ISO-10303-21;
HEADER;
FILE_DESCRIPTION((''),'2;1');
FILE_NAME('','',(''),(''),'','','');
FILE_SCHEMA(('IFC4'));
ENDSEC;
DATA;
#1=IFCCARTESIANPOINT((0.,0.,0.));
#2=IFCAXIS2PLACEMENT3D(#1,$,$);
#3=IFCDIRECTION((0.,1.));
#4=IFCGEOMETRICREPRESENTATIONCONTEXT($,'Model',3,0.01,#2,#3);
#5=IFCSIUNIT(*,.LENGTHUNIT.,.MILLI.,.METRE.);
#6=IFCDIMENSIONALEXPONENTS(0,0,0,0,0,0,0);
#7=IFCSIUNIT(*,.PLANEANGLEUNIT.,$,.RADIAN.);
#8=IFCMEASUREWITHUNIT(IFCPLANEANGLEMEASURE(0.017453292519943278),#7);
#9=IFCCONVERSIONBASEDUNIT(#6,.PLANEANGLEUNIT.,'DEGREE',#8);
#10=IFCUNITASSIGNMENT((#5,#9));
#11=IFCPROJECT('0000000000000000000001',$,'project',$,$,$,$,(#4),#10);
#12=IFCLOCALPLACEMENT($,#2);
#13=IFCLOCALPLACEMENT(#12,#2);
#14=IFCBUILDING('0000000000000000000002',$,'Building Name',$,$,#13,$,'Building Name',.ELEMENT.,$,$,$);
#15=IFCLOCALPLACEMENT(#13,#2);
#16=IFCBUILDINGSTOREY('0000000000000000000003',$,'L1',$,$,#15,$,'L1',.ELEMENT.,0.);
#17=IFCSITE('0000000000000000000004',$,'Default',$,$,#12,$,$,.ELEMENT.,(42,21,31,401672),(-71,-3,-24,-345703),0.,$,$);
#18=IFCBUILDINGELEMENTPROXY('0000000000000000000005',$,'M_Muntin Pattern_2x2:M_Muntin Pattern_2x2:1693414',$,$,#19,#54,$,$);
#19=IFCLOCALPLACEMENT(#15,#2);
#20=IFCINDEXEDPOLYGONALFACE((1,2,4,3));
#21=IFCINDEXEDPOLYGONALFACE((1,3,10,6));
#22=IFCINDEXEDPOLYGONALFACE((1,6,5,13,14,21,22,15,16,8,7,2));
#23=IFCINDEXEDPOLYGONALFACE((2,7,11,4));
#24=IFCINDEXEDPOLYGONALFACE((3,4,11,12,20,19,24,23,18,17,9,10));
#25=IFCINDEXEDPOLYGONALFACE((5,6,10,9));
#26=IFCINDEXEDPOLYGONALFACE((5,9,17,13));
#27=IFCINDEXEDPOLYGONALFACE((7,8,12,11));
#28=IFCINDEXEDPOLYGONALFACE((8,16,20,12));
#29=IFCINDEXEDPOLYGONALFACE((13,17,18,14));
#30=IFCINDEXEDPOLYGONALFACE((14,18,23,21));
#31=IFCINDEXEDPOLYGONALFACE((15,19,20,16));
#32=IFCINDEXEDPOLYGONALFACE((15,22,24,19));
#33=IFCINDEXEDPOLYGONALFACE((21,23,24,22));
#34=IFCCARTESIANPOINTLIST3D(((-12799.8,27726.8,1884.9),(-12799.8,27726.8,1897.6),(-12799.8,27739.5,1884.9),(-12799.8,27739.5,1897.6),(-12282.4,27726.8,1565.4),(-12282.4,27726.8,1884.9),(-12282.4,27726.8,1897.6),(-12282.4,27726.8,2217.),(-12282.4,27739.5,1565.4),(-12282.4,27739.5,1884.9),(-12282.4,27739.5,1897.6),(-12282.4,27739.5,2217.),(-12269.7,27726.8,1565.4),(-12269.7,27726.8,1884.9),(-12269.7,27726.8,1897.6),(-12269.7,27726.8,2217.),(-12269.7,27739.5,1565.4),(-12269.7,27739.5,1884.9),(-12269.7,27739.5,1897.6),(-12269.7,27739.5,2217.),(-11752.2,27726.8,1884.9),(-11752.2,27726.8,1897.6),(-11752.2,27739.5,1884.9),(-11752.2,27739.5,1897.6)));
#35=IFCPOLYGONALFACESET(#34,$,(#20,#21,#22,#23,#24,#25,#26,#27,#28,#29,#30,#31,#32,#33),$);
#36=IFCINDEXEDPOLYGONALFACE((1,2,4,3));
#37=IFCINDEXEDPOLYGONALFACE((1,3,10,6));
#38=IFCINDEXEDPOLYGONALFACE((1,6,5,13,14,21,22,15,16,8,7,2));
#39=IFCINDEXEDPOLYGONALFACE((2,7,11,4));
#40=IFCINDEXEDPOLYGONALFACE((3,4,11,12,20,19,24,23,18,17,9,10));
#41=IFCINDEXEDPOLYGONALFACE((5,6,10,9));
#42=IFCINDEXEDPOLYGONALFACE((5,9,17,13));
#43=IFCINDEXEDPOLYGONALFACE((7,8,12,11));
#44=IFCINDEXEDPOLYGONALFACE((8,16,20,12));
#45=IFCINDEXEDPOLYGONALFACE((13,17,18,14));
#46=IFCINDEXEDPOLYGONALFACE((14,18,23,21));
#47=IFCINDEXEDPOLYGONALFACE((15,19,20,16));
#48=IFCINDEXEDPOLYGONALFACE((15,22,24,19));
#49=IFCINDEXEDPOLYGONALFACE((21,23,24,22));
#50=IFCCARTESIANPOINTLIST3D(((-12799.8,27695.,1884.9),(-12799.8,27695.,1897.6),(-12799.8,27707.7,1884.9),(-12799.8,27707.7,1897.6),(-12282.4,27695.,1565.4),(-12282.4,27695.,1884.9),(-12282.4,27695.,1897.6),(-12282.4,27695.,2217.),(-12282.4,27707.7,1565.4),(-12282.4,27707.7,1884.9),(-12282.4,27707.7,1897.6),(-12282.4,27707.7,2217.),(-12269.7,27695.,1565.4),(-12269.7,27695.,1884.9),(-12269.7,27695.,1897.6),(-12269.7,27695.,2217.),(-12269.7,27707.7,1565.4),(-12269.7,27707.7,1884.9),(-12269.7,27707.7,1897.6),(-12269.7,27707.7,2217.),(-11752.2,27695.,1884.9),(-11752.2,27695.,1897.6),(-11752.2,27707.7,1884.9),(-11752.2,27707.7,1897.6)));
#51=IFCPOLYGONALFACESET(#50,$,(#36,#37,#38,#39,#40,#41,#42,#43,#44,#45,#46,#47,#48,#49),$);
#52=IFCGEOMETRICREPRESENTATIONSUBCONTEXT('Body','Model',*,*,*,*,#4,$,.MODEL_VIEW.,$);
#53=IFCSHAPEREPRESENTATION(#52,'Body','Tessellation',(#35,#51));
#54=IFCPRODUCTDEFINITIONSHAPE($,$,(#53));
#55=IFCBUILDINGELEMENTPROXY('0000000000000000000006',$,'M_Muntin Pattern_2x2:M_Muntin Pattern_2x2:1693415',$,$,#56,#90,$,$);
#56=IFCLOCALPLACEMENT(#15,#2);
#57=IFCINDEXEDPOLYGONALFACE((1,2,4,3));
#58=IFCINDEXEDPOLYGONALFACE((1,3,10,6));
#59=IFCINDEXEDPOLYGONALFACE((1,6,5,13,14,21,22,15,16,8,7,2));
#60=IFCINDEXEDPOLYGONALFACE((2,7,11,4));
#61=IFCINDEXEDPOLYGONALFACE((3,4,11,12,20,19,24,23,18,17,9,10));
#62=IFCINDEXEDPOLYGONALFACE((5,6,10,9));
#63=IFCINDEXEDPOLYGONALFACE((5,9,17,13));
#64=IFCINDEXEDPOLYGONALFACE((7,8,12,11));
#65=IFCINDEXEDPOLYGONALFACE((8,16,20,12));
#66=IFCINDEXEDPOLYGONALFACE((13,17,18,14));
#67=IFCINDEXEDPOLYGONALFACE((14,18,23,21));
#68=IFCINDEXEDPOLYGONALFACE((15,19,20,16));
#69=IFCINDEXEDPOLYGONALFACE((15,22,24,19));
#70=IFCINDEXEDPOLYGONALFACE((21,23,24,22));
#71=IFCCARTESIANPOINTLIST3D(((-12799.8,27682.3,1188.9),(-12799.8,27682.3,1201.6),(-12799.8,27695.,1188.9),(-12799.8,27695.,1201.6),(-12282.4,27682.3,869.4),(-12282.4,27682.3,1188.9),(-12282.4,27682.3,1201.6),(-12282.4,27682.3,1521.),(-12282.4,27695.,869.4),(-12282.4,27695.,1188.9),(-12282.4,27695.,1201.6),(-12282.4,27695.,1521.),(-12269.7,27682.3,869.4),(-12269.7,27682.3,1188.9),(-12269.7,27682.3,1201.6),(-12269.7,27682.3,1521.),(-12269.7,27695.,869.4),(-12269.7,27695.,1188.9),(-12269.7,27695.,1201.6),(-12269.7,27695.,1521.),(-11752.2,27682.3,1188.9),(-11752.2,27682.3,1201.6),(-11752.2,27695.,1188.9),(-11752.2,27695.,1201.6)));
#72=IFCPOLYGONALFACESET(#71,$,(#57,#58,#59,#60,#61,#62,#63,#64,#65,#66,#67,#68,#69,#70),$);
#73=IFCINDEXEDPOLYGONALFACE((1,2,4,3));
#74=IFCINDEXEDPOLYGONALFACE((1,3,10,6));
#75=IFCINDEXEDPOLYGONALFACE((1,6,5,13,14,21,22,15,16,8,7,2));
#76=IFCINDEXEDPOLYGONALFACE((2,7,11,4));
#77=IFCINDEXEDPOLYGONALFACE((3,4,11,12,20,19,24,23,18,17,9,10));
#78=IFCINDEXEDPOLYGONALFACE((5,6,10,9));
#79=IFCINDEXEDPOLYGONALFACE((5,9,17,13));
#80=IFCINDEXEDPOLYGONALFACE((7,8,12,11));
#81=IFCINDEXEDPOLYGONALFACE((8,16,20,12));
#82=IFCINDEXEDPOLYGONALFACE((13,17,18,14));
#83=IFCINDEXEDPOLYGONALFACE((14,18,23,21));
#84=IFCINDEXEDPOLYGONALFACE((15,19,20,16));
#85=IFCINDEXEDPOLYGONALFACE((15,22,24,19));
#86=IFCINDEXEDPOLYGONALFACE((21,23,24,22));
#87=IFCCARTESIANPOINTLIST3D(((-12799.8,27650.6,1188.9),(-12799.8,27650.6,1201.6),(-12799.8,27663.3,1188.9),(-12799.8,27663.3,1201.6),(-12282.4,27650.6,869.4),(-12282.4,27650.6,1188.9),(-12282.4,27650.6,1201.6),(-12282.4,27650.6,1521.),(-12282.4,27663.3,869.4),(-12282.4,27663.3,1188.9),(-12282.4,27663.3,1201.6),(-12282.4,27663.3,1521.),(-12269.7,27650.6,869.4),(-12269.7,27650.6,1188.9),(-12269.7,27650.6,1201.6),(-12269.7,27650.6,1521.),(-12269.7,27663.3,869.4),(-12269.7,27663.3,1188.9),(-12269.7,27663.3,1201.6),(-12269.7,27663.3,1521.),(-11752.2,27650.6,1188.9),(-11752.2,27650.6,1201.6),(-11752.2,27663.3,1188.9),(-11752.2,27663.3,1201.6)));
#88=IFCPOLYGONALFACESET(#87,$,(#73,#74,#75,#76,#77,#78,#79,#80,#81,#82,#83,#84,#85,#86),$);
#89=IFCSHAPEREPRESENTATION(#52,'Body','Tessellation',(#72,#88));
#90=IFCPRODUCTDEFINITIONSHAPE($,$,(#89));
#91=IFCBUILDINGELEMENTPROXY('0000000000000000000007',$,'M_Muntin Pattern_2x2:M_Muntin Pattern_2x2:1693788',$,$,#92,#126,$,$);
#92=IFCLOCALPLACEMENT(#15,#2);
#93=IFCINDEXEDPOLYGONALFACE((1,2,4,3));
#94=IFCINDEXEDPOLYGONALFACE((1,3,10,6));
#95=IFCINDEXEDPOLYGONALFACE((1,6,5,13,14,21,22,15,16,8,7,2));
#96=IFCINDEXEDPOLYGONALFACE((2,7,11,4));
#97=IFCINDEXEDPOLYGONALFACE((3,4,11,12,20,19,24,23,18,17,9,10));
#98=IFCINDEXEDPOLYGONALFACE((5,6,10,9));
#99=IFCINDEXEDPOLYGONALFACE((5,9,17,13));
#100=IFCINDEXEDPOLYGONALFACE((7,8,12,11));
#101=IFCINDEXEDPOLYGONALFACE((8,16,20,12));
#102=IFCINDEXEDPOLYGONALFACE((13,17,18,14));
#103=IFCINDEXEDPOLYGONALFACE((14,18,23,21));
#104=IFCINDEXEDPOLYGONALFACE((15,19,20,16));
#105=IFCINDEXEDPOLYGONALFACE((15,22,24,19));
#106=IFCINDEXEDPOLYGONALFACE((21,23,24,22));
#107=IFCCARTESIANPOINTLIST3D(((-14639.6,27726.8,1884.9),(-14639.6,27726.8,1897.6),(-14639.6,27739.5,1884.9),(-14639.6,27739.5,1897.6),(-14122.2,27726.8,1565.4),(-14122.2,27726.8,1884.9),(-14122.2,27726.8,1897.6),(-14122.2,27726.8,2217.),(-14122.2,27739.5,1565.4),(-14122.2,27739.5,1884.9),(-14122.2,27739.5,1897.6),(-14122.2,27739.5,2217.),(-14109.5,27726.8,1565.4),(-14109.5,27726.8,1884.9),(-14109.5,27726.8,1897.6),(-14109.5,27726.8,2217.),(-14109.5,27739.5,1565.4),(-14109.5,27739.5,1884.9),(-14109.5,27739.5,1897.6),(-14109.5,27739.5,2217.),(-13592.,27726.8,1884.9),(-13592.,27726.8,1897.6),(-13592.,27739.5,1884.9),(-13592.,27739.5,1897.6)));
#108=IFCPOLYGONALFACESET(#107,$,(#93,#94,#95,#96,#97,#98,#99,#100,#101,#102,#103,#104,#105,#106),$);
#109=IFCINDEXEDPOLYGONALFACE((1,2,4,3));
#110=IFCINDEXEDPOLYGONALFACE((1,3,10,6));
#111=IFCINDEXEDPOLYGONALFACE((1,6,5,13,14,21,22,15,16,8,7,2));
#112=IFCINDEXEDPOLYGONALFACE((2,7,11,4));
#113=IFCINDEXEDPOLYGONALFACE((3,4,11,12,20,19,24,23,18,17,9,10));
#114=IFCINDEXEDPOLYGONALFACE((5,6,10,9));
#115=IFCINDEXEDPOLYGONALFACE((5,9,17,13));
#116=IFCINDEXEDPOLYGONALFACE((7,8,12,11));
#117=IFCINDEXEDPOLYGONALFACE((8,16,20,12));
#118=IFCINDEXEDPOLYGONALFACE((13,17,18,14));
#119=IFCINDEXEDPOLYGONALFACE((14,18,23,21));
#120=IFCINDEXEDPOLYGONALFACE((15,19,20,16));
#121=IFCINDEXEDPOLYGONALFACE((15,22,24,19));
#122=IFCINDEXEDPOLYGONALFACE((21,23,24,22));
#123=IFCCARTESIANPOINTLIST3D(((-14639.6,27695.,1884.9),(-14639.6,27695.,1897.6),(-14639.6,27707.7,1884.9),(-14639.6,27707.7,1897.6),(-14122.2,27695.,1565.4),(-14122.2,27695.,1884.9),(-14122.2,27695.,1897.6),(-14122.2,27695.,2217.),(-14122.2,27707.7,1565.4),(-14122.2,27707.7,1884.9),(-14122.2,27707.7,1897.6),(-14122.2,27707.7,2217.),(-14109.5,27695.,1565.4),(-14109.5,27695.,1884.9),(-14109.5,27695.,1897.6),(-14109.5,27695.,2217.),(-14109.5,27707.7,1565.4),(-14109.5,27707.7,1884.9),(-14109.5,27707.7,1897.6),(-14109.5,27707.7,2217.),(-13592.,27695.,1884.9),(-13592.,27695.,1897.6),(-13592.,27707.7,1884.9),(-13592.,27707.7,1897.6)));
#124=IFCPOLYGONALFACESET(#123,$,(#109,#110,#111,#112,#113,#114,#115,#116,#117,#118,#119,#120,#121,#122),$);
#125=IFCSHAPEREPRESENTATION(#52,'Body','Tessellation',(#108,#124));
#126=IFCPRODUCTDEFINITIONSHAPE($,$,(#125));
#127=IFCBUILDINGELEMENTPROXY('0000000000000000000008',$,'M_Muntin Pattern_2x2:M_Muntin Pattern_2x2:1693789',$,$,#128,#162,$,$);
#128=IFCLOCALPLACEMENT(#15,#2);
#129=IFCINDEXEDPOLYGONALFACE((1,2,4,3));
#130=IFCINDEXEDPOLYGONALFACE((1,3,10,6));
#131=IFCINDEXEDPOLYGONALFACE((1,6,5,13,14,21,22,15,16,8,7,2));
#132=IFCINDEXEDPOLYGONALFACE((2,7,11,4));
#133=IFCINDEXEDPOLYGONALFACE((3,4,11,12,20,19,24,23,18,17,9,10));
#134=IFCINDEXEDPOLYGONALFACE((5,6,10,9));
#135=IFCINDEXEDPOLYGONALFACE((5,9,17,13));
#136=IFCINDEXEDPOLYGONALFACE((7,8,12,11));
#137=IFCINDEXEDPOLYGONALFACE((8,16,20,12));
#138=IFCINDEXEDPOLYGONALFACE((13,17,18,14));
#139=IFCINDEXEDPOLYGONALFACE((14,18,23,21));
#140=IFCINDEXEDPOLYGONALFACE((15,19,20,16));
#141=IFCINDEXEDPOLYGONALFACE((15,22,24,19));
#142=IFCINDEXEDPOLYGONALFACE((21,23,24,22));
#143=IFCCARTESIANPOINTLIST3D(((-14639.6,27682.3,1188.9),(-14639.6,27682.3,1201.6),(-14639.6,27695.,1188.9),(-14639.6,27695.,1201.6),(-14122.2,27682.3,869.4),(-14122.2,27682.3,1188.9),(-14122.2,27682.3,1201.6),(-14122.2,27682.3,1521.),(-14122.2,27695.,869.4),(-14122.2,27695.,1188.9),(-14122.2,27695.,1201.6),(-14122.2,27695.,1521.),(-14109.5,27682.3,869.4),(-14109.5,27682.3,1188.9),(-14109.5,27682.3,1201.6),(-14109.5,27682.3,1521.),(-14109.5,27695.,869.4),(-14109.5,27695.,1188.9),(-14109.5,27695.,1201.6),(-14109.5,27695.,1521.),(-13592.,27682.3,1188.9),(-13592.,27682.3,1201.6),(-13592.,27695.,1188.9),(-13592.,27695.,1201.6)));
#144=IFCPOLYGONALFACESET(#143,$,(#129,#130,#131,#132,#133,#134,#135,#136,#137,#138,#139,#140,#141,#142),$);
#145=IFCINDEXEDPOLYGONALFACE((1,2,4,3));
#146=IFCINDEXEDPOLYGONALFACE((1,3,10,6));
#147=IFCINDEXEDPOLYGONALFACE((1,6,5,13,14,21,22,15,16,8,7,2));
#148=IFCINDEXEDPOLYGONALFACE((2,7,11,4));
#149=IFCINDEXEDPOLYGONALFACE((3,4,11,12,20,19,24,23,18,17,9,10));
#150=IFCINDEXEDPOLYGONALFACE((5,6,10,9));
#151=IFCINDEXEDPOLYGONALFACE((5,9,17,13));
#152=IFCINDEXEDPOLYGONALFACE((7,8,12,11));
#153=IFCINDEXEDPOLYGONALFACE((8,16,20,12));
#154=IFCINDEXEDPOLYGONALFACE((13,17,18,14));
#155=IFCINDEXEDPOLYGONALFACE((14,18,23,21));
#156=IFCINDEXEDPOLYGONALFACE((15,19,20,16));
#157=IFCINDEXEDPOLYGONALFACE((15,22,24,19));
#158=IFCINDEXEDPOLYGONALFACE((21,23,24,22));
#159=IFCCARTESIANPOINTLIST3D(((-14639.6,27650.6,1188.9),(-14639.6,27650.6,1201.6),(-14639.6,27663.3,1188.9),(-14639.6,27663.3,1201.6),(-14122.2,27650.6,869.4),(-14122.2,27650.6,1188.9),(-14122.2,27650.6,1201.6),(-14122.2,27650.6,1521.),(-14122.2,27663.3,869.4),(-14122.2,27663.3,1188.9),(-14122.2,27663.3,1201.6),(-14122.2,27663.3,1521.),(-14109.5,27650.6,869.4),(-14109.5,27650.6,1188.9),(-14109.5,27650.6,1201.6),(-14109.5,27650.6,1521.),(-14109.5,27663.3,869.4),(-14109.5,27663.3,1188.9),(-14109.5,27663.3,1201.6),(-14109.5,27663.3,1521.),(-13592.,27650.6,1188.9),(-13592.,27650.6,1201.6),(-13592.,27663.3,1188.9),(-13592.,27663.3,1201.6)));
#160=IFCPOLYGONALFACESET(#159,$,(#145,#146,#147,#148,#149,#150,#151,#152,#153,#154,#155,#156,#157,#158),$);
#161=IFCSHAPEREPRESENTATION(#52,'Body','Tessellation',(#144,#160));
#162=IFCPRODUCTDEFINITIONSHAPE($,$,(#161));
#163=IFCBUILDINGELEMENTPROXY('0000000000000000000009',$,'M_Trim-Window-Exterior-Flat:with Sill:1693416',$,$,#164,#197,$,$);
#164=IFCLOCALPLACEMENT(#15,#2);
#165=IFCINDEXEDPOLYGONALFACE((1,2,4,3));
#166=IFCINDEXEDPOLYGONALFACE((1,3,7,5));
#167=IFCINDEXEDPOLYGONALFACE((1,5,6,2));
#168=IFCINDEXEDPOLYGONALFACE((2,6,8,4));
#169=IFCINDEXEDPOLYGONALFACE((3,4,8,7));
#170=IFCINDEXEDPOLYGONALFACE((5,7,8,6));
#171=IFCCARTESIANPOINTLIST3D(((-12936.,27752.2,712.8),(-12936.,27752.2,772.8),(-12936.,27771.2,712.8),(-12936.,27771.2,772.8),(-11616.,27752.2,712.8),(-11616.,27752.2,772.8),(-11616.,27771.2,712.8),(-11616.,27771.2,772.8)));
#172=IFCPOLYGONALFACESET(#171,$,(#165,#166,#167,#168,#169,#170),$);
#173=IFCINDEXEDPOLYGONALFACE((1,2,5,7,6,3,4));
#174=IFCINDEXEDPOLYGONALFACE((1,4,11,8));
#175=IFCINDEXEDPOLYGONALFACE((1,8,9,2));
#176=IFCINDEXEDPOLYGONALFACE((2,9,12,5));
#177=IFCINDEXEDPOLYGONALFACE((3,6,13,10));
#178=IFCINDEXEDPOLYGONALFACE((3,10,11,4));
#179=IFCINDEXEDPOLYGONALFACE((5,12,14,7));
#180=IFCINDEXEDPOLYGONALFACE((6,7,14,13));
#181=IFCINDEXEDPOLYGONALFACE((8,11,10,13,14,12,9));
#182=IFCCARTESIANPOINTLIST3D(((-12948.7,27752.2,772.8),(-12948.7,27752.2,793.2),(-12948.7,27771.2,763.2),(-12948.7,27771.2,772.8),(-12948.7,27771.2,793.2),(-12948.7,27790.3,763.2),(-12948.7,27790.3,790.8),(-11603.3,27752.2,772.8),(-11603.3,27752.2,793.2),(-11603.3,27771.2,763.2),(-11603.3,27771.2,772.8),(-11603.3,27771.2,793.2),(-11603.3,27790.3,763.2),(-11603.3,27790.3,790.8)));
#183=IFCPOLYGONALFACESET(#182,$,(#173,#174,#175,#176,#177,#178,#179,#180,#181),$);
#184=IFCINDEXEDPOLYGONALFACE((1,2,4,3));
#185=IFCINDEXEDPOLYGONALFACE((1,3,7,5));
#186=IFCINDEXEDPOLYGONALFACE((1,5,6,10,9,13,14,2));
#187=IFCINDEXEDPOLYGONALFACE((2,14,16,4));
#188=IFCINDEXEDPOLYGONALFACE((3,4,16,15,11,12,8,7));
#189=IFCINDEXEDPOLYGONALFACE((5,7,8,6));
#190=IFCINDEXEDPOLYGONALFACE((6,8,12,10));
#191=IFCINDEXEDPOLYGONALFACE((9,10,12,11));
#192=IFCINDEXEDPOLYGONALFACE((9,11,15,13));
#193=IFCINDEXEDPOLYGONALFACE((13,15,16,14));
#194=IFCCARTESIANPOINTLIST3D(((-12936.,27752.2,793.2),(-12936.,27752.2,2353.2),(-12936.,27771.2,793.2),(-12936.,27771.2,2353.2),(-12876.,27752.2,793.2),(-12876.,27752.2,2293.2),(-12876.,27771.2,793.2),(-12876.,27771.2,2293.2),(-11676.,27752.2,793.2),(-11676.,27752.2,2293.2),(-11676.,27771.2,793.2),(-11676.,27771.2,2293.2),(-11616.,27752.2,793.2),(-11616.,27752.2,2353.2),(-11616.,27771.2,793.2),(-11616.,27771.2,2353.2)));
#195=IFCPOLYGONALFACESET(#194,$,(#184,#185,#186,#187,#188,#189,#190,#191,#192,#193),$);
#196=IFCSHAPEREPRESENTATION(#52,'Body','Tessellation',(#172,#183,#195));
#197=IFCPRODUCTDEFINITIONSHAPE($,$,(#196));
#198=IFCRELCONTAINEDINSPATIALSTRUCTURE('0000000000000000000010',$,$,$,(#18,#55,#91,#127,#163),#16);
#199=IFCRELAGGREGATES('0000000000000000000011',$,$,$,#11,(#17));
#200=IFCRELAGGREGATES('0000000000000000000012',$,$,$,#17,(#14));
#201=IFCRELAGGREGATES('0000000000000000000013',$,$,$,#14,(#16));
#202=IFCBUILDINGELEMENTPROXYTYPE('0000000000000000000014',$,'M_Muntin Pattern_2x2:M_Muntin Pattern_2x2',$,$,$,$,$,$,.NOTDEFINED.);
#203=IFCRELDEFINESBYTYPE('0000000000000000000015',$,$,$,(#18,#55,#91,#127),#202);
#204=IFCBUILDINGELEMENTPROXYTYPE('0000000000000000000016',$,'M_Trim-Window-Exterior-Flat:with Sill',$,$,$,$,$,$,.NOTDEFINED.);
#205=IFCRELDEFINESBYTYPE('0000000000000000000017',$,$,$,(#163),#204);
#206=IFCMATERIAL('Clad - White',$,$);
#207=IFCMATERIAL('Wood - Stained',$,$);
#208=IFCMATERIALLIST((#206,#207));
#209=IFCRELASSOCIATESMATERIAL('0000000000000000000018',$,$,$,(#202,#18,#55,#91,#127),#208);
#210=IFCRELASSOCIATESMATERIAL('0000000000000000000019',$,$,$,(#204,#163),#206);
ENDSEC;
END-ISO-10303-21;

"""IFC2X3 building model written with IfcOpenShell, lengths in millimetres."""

from ifc_helpers import new_model, entity, si_unit, converted_unit, direction, frame, frame_2d, origin, place, context, subcontext, project, spatial, polyline, rectangle, outline, extrude, source, transform, mapped, material, material_list, type_object, type_shapes, element, save


model = new_model("IFC2X3")

# Units and contexts
model_context = context("Model", 3, precision=0.01, world=origin(), true_north=direction((0.0, 1.0)))
body_context = subcontext(model_context, "Body", "Model", "MODEL_VIEW")
ifc_project = project(units=[si_unit("LENGTHUNIT", "METRE", prefix="MILLI"), converted_unit("PLANEANGLEUNIT", "DEGREE", entity("IfcPlaneAngleMeasure", 0.017453292519943278), si_unit("PLANEANGLEUNIT", "RADIAN"), dimensions=[0, 0, 0, 0, 0, 0, 0])], contexts=[model_context])

# Site, building, storey
site_placement = place(None, origin())
site = spatial("IfcSite", under=ifc_project, at=site_placement, Name="Default", CompositionType="ELEMENT", RefLatitude=(42, 21, 31, 401672), RefLongitude=(-71, -3, -24, -345703), RefElevation=0.0)
building_placement = place(site_placement, origin())
building = spatial("IfcBuilding", under=site, at=building_placement, Name="Building Name", LongName="Building Name", CompositionType="ELEMENT")
storey_placement = place(building_placement, origin())
storey = spatial("IfcBuildingStorey", under=building, at=storey_placement, Name="L1", LongName="L1", CompositionType="ELEMENT", Elevation=0.0)

# Shared definitions
ifc_material_1 = material(Name="Wood - Stained")

# Building element proxies
ifc_material_2 = material(Name="Clad - White")
ifc_material_list_1 = material_list([ifc_material_2, ifc_material_1])
building_element_proxy_type_1 = type_object("IfcBuildingElementProxyType", Name="M_Muntin Pattern_2x2:M_Muntin Pattern_2x2", PredefinedType="NOTDEFINED", material=ifc_material_list_1)
shared_shape_1 = source(origin(), body_context, "Body", "SweptSolid", [
    extrude(outline(polyline([(6.4, -6.4), (325.8, -6.4), (325.8, 6.3), (6.4, 6.3), (6.4, 523.8), (-6.3, 523.8), (-6.3, 6.3), (-325.8, 6.3), (-325.8, -6.4), (-6.3, -6.4), (-6.3, -523.8), (6.4, -523.8), (6.4, -6.4)])), frame((0.0, 9.5, 325.8), z_axis=(0.0, 1.0, 0.0), x_axis=(0.0, 0.0, 1.0)), (0.0, 0.0, 1.0), 12.7),
    extrude(outline(polyline([(6.4, -6.4), (325.8, -6.4), (325.8, 6.3), (6.4, 6.3), (6.4, 523.8), (-6.3, 523.8), (-6.3, 6.3), (-325.8, 6.3), (-325.8, -6.4), (-6.3, -6.4), (-6.3, -523.8), (6.4, -523.8), (6.4, -6.4)])), frame((0.0, -22.2, 325.8), z_axis=(0.0, 1.0, 0.0), x_axis=(0.0, 0.0, 1.0)), (0.0, 0.0, 1.0), 12.7),
])
type_shapes(building_element_proxy_type_1, [shared_shape_1])
for number, where, name in (
    (1, (-12276.0, 27717.2, 1565.4), "M_Muntin Pattern_2x2:M_Muntin Pattern_2x2:1693414"),
    (2, (-12276.0, 27672.8, 869.4), "M_Muntin Pattern_2x2:M_Muntin Pattern_2x2:1693415"),
    (3, (-14115.8, 27717.2, 1565.4), "M_Muntin Pattern_2x2:M_Muntin Pattern_2x2:1693788"),
    (4, (-14115.8, 27672.8, 869.4), "M_Muntin Pattern_2x2:M_Muntin Pattern_2x2:1693789"),
):
    element("IfcBuildingElementProxy", number, at=place(storey_placement, frame(where)), inside=storey, type_object=building_element_proxy_type_1, material=ifc_material_list_1, Name=name, context=body_context, shape_type="MappedRepresentation", body=[
        mapped(shared_shape_1, transform((0.0, 0.0, 0.0), scale=1.0)),
    ])
building_element_proxy_type_2 = type_object("IfcBuildingElementProxyType", Name="M_Trim-Window-Exterior-Flat:with Sill", PredefinedType="NOTDEFINED", material=ifc_material_2)
shared_shape_2 = source(origin(), body_context, "Body", "SweptSolid", [
    extrude(rectangle(XDim=1320.0, YDim=60.0, at=frame_2d((0.0, 0.0), x_axis=(1.0, 0.0))), frame((0.0, -1550.4, 0.0), z_axis=(0.0, 0.0, 1.0), x_axis=(-1.0, 0.0, 0.0)), (0.0, 0.0, 1.0), 19.0),
    extrude(outline(polyline([(-19.0, -15.2), (0.0, -15.2), (0.0, -5.7), (19.0, -5.7), (19.0, 14.8), (0.0, 14.8), (-19.0, 12.3), (-19.0, -15.2)])), frame((-672.7, -1514.8, 19.0), z_axis=(1.0, 0.0, 0.0), x_axis=(0.0, 0.0, -1.0)), (0.0, 0.0, 1.0), 1345.4),
    extrude(outline(polyline([(-795.0, -660.0), (765.0, -660.0), (765.0, -600.0), (-735.0, -600.0), (-735.0, 600.0), (765.0, 600.0), (765.0, 660.0), (-795.0, 660.0), (-795.0, -660.0)])), frame((0.0, -735.0, 0.0), z_axis=(0.0, 0.0, 1.0), x_axis=(0.0, -1.0, 0.0)), (0.0, 0.0, 1.0), 19.0),
])
type_shapes(building_element_proxy_type_2, [shared_shape_2])
for number, where, z_axis, x_axis, name in (
    (5, (-12276.0, 27752.2, 2293.2), (0.0, 1.0, 0.0), (-1.0, 0.0, 0.0), "M_Trim-Window-Exterior-Flat:with Sill:1693416"),
):
    element("IfcBuildingElementProxy", number, at=place(storey_placement, frame(where, z_axis=z_axis, x_axis=x_axis)), inside=storey, type_object=building_element_proxy_type_2, material=ifc_material_2, Name=name, context=body_context, shape_type="MappedRepresentation", body=[
        mapped(shared_shape_2, transform((0.0, 0.0, 0.0), scale=1.0)),
    ])

save(model, "model.ifc")
